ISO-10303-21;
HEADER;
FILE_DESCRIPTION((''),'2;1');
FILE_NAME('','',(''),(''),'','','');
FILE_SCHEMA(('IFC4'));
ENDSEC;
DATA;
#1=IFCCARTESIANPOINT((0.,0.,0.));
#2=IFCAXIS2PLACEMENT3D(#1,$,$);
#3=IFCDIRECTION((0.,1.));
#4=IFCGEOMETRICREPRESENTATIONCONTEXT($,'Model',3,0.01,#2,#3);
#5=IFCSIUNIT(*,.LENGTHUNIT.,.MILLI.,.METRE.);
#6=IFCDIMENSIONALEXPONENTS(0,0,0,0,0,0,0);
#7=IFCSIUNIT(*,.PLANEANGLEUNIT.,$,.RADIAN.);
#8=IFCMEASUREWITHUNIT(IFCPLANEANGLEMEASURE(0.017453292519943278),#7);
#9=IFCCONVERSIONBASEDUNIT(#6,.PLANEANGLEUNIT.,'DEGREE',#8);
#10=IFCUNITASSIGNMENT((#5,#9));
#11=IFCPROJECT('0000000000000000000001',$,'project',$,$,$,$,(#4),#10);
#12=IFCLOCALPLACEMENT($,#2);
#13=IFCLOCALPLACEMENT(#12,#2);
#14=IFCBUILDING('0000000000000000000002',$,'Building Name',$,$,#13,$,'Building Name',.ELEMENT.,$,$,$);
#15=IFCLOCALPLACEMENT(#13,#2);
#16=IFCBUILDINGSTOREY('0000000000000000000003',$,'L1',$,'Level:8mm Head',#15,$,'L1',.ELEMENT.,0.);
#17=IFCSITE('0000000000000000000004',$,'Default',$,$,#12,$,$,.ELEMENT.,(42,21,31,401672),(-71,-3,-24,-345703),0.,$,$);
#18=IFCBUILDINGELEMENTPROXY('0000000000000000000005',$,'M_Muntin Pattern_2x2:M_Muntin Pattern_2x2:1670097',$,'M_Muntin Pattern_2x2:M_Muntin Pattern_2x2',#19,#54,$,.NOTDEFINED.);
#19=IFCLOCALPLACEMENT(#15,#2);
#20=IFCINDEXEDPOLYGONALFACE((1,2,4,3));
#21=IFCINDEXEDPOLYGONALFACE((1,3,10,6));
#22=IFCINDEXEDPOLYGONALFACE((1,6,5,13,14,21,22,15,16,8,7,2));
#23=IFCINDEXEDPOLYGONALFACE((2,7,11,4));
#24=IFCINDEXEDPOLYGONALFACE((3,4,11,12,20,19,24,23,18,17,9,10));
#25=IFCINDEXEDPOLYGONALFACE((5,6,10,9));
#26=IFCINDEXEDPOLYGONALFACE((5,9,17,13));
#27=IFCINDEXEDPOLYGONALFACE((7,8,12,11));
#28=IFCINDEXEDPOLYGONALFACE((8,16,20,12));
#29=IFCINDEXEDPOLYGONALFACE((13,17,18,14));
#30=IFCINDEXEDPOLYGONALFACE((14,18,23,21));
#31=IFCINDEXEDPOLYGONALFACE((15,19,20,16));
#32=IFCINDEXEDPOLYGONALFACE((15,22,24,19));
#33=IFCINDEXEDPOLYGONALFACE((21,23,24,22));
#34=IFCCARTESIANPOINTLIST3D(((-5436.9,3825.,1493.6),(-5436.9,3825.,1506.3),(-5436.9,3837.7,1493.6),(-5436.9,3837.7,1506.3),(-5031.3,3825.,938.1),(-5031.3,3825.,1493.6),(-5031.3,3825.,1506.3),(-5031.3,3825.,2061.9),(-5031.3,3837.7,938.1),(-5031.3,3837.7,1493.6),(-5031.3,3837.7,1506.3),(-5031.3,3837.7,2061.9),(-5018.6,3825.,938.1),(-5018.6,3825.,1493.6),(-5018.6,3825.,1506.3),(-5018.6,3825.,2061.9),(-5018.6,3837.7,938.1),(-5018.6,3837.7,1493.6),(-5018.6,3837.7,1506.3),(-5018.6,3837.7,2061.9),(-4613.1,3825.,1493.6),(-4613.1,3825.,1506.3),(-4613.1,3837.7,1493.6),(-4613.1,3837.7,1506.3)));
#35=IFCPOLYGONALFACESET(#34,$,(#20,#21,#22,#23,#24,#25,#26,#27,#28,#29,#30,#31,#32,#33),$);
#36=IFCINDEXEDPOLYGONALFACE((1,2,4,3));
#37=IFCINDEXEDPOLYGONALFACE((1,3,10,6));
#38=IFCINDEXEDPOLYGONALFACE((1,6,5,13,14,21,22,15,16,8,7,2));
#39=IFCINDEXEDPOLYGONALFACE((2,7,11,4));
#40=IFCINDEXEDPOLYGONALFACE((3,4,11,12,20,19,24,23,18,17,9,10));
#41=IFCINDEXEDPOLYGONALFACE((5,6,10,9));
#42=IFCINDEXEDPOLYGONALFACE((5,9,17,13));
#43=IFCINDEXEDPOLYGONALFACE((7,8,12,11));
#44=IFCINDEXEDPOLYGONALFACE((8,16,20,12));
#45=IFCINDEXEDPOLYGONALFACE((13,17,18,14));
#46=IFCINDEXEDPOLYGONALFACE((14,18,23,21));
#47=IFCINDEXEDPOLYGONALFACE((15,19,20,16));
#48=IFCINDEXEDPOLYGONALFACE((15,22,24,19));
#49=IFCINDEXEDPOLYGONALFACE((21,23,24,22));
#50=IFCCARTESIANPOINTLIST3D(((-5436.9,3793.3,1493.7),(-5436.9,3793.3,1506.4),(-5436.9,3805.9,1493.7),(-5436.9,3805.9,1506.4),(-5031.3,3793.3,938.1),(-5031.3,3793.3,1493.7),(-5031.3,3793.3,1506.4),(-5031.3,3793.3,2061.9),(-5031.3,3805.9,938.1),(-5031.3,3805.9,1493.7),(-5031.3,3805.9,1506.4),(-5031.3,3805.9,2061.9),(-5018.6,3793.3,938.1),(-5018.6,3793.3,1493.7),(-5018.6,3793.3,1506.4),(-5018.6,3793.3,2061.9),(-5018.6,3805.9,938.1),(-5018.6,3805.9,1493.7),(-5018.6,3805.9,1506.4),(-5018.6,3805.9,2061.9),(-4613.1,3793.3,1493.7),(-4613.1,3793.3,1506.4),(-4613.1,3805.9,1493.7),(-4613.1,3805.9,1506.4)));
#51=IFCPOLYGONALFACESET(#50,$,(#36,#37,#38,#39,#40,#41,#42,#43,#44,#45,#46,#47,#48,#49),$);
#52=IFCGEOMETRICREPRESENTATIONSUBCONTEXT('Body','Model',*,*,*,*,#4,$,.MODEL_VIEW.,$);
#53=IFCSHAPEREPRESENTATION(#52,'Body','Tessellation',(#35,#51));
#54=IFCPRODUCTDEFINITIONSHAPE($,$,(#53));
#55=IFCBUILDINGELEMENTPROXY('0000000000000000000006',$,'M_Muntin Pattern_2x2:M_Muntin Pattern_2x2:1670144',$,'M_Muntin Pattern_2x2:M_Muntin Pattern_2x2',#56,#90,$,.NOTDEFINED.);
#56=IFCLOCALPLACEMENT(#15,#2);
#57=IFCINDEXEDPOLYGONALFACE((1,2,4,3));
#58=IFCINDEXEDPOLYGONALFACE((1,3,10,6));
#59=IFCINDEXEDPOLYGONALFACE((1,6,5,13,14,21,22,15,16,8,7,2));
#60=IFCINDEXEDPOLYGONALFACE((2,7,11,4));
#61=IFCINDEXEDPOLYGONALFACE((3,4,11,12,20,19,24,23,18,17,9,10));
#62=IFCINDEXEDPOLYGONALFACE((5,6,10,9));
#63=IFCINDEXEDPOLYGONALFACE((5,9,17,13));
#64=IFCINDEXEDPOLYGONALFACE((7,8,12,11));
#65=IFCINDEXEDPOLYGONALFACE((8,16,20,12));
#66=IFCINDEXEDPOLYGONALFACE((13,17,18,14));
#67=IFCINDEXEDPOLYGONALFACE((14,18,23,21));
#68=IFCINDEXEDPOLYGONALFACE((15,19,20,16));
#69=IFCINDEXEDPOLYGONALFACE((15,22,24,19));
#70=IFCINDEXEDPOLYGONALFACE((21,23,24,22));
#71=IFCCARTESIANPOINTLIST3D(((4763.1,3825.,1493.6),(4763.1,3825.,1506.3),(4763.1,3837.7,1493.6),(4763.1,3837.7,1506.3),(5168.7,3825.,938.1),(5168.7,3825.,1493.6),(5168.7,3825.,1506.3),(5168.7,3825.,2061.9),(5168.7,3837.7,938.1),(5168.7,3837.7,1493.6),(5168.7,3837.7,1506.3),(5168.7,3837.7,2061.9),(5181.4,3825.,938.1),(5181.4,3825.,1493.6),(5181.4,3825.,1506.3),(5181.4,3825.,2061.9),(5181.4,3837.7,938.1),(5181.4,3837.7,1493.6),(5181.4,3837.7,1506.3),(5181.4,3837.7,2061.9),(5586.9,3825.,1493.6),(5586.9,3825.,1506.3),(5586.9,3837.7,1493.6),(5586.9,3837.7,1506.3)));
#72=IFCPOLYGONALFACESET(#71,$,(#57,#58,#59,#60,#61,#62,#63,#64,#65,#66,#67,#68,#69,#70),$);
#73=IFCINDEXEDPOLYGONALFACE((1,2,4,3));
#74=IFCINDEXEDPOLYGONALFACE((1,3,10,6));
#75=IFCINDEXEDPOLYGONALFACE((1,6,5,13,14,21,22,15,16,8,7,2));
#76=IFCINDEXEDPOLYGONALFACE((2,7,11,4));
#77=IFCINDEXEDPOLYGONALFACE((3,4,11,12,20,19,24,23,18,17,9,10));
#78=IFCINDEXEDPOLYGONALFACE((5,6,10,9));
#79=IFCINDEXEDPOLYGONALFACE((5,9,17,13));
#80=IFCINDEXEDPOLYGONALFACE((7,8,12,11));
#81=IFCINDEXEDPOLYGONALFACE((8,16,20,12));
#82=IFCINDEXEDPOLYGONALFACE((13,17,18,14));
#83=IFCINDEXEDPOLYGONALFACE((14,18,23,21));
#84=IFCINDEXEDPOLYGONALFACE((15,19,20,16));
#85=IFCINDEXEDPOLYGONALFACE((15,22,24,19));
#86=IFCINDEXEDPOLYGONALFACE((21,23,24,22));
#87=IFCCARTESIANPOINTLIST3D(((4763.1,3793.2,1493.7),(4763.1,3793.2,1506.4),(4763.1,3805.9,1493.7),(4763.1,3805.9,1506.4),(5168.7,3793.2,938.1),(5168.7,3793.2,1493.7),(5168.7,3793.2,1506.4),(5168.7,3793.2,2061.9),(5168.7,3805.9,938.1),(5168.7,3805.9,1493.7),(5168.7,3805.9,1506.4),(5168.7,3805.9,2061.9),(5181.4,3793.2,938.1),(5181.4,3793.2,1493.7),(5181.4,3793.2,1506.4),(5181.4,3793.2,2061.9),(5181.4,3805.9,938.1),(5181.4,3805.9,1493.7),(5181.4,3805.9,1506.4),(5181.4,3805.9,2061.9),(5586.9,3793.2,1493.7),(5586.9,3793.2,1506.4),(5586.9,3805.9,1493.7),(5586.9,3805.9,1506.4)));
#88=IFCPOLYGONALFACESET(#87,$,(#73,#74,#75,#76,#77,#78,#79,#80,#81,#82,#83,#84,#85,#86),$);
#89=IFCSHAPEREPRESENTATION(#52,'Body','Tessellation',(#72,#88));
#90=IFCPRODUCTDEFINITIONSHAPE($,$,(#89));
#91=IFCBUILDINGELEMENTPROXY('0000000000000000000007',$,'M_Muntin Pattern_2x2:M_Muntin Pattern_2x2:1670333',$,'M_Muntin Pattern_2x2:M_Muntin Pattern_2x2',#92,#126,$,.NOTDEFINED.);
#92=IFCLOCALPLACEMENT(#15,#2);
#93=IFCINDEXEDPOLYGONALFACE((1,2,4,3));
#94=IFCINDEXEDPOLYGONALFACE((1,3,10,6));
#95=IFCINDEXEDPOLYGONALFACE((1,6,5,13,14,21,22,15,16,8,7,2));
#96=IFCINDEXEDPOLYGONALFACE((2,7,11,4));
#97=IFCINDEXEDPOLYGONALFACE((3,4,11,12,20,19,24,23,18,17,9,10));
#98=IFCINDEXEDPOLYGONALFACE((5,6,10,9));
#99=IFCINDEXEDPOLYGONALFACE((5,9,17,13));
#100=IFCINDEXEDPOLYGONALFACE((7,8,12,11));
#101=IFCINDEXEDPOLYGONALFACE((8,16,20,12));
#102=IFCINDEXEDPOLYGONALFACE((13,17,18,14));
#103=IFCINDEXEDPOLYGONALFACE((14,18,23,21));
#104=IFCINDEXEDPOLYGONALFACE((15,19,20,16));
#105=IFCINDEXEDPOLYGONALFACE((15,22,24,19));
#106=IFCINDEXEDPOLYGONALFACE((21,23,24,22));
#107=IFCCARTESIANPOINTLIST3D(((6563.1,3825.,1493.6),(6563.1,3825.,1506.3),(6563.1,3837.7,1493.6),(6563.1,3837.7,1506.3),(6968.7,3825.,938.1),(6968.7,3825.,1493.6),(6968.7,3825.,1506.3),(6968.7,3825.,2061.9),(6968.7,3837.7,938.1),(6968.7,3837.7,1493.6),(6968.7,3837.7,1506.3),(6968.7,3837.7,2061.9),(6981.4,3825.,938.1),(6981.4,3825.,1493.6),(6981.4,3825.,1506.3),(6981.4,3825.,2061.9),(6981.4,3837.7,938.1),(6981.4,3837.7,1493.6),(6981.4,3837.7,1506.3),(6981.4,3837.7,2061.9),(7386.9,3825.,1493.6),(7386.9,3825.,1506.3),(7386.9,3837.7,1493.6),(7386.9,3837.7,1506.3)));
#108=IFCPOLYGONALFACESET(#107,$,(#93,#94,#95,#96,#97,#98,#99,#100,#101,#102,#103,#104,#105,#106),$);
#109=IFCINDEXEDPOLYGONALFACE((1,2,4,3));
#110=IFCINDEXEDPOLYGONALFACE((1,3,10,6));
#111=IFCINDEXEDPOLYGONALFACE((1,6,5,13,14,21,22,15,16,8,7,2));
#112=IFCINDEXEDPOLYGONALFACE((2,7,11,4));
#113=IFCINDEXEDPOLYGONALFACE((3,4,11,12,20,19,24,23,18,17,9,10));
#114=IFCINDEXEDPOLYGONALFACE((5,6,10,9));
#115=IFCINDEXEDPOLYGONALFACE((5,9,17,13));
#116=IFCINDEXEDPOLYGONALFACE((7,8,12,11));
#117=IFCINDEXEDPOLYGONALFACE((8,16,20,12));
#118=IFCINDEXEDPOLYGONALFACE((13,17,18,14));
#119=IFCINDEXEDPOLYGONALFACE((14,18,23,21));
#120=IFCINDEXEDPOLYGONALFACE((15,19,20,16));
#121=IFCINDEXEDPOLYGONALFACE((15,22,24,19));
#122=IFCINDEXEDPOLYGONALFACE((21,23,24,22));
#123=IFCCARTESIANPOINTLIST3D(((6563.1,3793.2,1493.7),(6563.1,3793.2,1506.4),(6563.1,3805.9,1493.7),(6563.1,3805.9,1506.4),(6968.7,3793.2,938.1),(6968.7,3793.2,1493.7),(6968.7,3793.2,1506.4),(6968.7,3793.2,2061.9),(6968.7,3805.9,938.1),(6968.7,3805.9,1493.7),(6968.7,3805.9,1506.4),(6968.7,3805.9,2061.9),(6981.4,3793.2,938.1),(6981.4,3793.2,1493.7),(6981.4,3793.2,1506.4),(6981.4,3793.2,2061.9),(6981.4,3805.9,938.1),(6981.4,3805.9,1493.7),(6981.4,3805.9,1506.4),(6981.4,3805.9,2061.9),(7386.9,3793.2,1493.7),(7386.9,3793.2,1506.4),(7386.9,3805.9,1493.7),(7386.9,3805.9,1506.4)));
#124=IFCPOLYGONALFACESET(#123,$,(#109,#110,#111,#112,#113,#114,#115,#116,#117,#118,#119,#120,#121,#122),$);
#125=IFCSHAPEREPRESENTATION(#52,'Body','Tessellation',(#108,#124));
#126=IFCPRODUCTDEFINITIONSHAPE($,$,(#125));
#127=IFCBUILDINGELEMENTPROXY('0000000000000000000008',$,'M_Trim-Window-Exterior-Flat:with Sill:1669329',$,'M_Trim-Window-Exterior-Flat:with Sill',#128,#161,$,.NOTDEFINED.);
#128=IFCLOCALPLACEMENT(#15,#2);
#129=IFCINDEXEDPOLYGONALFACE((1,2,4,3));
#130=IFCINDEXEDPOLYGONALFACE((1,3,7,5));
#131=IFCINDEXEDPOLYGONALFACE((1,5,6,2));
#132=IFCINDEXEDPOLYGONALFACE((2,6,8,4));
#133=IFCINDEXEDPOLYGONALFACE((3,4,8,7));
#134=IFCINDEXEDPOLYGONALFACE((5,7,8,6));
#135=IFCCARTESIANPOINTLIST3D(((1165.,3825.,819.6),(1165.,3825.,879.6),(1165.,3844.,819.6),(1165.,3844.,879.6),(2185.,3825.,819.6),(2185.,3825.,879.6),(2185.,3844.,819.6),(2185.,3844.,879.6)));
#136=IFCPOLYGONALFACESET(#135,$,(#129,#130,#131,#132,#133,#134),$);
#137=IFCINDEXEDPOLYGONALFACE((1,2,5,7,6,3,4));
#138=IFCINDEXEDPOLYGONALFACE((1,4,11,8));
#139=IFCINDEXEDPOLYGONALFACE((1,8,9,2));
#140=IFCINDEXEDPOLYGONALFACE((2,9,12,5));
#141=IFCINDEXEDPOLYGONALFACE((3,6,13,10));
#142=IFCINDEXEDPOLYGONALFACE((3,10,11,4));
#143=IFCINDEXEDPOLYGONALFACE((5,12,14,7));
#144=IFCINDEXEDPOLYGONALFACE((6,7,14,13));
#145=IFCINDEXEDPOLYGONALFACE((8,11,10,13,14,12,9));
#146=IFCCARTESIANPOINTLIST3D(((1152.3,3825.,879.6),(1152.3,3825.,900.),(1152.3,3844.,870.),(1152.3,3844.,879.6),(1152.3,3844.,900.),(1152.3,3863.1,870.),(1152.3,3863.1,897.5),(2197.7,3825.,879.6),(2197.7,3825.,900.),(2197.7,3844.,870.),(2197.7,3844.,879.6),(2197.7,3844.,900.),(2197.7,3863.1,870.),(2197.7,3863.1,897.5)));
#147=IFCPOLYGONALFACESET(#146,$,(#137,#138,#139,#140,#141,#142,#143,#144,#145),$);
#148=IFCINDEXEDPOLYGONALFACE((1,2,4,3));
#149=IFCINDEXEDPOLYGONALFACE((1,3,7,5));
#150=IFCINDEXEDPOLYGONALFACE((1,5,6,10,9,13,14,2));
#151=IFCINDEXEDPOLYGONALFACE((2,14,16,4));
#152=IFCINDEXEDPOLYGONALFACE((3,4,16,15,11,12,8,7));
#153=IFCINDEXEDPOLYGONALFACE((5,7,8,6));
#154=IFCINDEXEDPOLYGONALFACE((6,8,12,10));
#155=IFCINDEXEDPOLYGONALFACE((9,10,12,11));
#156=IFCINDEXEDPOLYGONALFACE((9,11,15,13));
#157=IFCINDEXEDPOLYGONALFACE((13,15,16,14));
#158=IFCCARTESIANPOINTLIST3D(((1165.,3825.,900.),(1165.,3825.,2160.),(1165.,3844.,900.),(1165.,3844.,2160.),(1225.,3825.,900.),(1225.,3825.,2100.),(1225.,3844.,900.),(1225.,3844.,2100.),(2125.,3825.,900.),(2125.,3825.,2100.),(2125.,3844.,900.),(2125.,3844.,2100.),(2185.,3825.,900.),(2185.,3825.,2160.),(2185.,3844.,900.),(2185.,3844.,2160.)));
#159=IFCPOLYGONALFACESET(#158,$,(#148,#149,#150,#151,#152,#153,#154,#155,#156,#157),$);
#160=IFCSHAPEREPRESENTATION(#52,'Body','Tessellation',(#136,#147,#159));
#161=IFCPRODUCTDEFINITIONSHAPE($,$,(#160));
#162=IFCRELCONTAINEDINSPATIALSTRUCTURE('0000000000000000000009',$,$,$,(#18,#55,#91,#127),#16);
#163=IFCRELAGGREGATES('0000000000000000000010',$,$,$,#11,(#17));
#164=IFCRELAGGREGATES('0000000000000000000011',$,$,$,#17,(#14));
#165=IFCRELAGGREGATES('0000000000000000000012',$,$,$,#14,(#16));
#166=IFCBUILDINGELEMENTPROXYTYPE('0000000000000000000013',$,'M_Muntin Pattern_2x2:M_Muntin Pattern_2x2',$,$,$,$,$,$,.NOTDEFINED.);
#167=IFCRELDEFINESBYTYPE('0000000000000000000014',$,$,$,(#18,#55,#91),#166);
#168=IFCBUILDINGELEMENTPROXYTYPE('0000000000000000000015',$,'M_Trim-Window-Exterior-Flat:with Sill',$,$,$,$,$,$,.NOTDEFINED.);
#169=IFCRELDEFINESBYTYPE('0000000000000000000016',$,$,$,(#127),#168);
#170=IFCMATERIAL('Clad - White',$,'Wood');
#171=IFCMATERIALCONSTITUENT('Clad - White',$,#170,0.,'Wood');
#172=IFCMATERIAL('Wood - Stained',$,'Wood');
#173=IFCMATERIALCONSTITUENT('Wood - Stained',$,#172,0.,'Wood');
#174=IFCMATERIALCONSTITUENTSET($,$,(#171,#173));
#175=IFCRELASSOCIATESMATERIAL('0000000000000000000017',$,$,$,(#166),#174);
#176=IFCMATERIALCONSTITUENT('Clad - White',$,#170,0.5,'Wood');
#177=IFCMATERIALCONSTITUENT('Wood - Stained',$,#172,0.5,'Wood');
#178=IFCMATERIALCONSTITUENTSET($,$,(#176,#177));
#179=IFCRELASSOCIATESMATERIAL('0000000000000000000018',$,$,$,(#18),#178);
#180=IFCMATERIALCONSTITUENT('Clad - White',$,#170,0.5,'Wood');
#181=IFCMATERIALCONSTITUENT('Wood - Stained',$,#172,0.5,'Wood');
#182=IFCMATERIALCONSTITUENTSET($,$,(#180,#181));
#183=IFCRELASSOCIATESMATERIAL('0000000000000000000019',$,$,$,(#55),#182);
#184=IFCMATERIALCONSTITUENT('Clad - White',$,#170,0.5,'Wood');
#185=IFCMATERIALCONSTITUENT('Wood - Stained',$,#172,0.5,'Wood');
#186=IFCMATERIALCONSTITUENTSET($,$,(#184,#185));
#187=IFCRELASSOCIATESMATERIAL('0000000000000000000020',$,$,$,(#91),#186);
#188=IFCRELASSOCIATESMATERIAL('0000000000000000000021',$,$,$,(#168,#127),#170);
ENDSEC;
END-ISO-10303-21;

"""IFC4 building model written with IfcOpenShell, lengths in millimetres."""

from ifc_helpers import new_model, entity, si_unit, converted_unit, direction, frame, frame_2d, origin, place, context, subcontext, project, spatial, polyline, rectangle, outline, extrude, source, transform, mapped, material, constituent, constituent_set, type_object, type_shapes, element, save


model = new_model("IFC4")

# Units and contexts
model_context = context("Model", 3, precision=0.01, world=origin(), true_north=direction((0.0, 1.0)))
body_context = subcontext(model_context, "Body", "Model", "MODEL_VIEW")
ifc_project = project(units=[si_unit("LENGTHUNIT", "METRE", prefix="MILLI"), converted_unit("PLANEANGLEUNIT", "DEGREE", entity("IfcPlaneAngleMeasure", 0.017453292519943278), si_unit("PLANEANGLEUNIT", "RADIAN"), dimensions=[0, 0, 0, 0, 0, 0, 0])], contexts=[model_context])

# Site, building, storey
site_placement = place(None, origin())
site = spatial("IfcSite", under=ifc_project, at=site_placement, Name="Default", CompositionType="ELEMENT", RefLatitude=(42, 21, 31, 401672), RefLongitude=(-71, -3, -24, -345703), RefElevation=0.0)
building_placement = place(site_placement, origin())
building = spatial("IfcBuilding", under=site, at=building_placement, Name="Building Name", LongName="Building Name", CompositionType="ELEMENT")
storey_placement = place(building_placement, origin())
storey = spatial("IfcBuildingStorey", under=building, at=storey_placement, Name="L1", ObjectType="Level:8mm Head", LongName="L1", CompositionType="ELEMENT", Elevation=0.0)

# Building element proxies
ifc_material_1 = material(Name="Clad - White", Category="Wood")
ifc_material_2 = material(Name="Wood - Stained", Category="Wood")
ifc_constituent_1 = constituent(ifc_material_1, Name="Clad - White", Category="Wood", fraction=0.0)
ifc_constituent_2 = constituent(ifc_material_2, Name="Wood - Stained", Category="Wood", fraction=0.0)
ifc_constituent_set_1 = constituent_set(constituents=[ifc_constituent_1, ifc_constituent_2])
building_element_proxy_type_1 = type_object("IfcBuildingElementProxyType", Name="M_Muntin Pattern_2x2:M_Muntin Pattern_2x2", PredefinedType="NOTDEFINED", material=ifc_constituent_set_1)
shared_shape_1 = source(origin(), body_context, "Body", "SweptSolid", [
    extrude(outline(polyline([(6.4, -6.4), (561.9, -6.4), (561.9, 6.3), (6.4, 6.3), (6.4, 411.9), (-6.3, 411.9), (-6.3, 6.3), (-561.9, 6.3), (-561.9, -6.4), (-6.3, -6.4), (-6.3, -411.9), (6.4, -411.9), (6.4, -6.4)])), frame((0.0, -22.2, 561.9), z_axis=(0.0, 1.0, 0.0), x_axis=(0.0, 0.0, 1.0)), (0.0, 0.0, 1.0), 12.7),
    extrude(outline(polyline([(6.4, -6.4), (561.9, -6.4), (561.9, 6.3), (6.4, 6.3), (6.4, 411.9), (-6.3, 411.9), (-6.3, 6.3), (-561.9, 6.3), (-561.9, -6.4), (-6.3, -6.4), (-6.3, -411.9), (6.4, -411.9), (6.4, -6.4)])), frame((0.0, 9.5, 561.9), z_axis=(0.0, 1.0, 0.0), x_axis=(0.0, 0.0, 1.0)), (0.0, 0.0, 1.0), 12.7),
])
type_shapes(building_element_proxy_type_1, [shared_shape_1])
ifc_constituent_3 = constituent(ifc_material_1, Name="Clad - White", Category="Wood", fraction=0.5)
ifc_constituent_4 = constituent(ifc_material_2, Name="Wood - Stained", Category="Wood", fraction=0.5)
ifc_constituent_set_2 = constituent_set(constituents=[ifc_constituent_3, ifc_constituent_4])
proxy_1_placement = place(storey_placement, frame((-5025.0, 3815.5, 938.1), z_axis=(0.0, 0.0, 1.0), x_axis=(-1.0, 0.0, 0.0)))
element("IfcBuildingElementProxy", 1, at=proxy_1_placement, inside=storey, type_object=building_element_proxy_type_1, material=ifc_constituent_set_2, Name="M_Muntin Pattern_2x2:M_Muntin Pattern_2x2:1670097", ObjectType="M_Muntin Pattern_2x2:M_Muntin Pattern_2x2", PredefinedType="NOTDEFINED", context=body_context, shape_type="MappedRepresentation", body=[
    mapped(shared_shape_1, transform((0.0, 0.0, 0.0), scale=1.0)),
])
ifc_constituent_5 = constituent(ifc_material_1, Name="Clad - White", Category="Wood", fraction=0.5)
ifc_constituent_6 = constituent(ifc_material_2, Name="Wood - Stained", Category="Wood", fraction=0.5)
ifc_constituent_set_3 = constituent_set(constituents=[ifc_constituent_5, ifc_constituent_6])
proxy_2_placement = place(storey_placement, frame((5175.0, 3815.5, 938.1), z_axis=(0.0, 0.0, 1.0), x_axis=(-1.0, 0.0, 0.0)))
element("IfcBuildingElementProxy", 2, at=proxy_2_placement, inside=storey, type_object=building_element_proxy_type_1, material=ifc_constituent_set_3, Name="M_Muntin Pattern_2x2:M_Muntin Pattern_2x2:1670144", ObjectType="M_Muntin Pattern_2x2:M_Muntin Pattern_2x2", PredefinedType="NOTDEFINED", context=body_context, shape_type="MappedRepresentation", body=[
    mapped(shared_shape_1, transform((0.0, 0.0, 0.0), scale=1.0)),
])
ifc_constituent_7 = constituent(ifc_material_1, Name="Clad - White", Category="Wood", fraction=0.5)
ifc_constituent_8 = constituent(ifc_material_2, Name="Wood - Stained", Category="Wood", fraction=0.5)
ifc_constituent_set_4 = constituent_set(constituents=[ifc_constituent_7, ifc_constituent_8])
proxy_3_placement = place(storey_placement, frame((6975.0, 3815.5, 938.1), z_axis=(0.0, 0.0, 1.0), x_axis=(-1.0, 0.0, 0.0)))
element("IfcBuildingElementProxy", 3, at=proxy_3_placement, inside=storey, type_object=building_element_proxy_type_1, material=ifc_constituent_set_4, Name="M_Muntin Pattern_2x2:M_Muntin Pattern_2x2:1670333", ObjectType="M_Muntin Pattern_2x2:M_Muntin Pattern_2x2", PredefinedType="NOTDEFINED", context=body_context, shape_type="MappedRepresentation", body=[
    mapped(shared_shape_1, transform((0.0, 0.0, 0.0), scale=1.0)),
])
building_element_proxy_type_2 = type_object("IfcBuildingElementProxyType", Name="M_Trim-Window-Exterior-Flat:with Sill", PredefinedType="NOTDEFINED", material=ifc_material_1)
shared_shape_2 = source(origin(), body_context, "Body", "SweptSolid", [
    extrude(rectangle(XDim=1020.0, YDim=60.0, at=frame_2d((0.0, 0.0), x_axis=(1.0, 0.0))), frame((0.0, -1250.4, 0.0), z_axis=(0.0, 0.0, 1.0), x_axis=(-1.0, 0.0, 0.0)), (0.0, 0.0, 1.0), 19.0),
    extrude(outline(polyline([(-19.0, -15.2), (0.0, -15.2), (0.0, -5.7), (19.0, -5.7), (19.0, 14.8), (0.0, 14.8), (-19.0, 12.3), (-19.0, -15.2)])), frame((-522.7, -1214.8, 19.0), z_axis=(1.0, 0.0, 0.0), x_axis=(0.0, 0.0, -1.0)), (0.0, 0.0, 1.0), 1045.4),
    extrude(outline(polyline([(-645.0, -510.0), (615.0, -510.0), (615.0, -450.0), (-585.0, -450.0), (-585.0, 450.0), (615.0, 450.0), (615.0, 510.0), (-645.0, 510.0), (-645.0, -510.0)])), frame((0.0, -585.0, 0.0), z_axis=(0.0, 0.0, 1.0), x_axis=(0.0, -1.0, 0.0)), (0.0, 0.0, 1.0), 19.0),
])
type_shapes(building_element_proxy_type_2, [shared_shape_2])
for number, where, z_axis, x_axis, name in (
    (4, (1675.0, 3825.0, 2100.0), (0.0, 1.0, 0.0), (-1.0, 0.0, 0.0), "M_Trim-Window-Exterior-Flat:with Sill:1669329"),
):
    element("IfcBuildingElementProxy", number, at=place(storey_placement, frame(where, z_axis=z_axis, x_axis=x_axis)), inside=storey, type_object=building_element_proxy_type_2, material=ifc_material_1, Name=name, ObjectType="M_Trim-Window-Exterior-Flat:with Sill", PredefinedType="NOTDEFINED", context=body_context, shape_type="MappedRepresentation", body=[
        mapped(shared_shape_2, transform((0.0, 0.0, 0.0), scale=1.0)),
    ])

save(model, "model.ifc")
